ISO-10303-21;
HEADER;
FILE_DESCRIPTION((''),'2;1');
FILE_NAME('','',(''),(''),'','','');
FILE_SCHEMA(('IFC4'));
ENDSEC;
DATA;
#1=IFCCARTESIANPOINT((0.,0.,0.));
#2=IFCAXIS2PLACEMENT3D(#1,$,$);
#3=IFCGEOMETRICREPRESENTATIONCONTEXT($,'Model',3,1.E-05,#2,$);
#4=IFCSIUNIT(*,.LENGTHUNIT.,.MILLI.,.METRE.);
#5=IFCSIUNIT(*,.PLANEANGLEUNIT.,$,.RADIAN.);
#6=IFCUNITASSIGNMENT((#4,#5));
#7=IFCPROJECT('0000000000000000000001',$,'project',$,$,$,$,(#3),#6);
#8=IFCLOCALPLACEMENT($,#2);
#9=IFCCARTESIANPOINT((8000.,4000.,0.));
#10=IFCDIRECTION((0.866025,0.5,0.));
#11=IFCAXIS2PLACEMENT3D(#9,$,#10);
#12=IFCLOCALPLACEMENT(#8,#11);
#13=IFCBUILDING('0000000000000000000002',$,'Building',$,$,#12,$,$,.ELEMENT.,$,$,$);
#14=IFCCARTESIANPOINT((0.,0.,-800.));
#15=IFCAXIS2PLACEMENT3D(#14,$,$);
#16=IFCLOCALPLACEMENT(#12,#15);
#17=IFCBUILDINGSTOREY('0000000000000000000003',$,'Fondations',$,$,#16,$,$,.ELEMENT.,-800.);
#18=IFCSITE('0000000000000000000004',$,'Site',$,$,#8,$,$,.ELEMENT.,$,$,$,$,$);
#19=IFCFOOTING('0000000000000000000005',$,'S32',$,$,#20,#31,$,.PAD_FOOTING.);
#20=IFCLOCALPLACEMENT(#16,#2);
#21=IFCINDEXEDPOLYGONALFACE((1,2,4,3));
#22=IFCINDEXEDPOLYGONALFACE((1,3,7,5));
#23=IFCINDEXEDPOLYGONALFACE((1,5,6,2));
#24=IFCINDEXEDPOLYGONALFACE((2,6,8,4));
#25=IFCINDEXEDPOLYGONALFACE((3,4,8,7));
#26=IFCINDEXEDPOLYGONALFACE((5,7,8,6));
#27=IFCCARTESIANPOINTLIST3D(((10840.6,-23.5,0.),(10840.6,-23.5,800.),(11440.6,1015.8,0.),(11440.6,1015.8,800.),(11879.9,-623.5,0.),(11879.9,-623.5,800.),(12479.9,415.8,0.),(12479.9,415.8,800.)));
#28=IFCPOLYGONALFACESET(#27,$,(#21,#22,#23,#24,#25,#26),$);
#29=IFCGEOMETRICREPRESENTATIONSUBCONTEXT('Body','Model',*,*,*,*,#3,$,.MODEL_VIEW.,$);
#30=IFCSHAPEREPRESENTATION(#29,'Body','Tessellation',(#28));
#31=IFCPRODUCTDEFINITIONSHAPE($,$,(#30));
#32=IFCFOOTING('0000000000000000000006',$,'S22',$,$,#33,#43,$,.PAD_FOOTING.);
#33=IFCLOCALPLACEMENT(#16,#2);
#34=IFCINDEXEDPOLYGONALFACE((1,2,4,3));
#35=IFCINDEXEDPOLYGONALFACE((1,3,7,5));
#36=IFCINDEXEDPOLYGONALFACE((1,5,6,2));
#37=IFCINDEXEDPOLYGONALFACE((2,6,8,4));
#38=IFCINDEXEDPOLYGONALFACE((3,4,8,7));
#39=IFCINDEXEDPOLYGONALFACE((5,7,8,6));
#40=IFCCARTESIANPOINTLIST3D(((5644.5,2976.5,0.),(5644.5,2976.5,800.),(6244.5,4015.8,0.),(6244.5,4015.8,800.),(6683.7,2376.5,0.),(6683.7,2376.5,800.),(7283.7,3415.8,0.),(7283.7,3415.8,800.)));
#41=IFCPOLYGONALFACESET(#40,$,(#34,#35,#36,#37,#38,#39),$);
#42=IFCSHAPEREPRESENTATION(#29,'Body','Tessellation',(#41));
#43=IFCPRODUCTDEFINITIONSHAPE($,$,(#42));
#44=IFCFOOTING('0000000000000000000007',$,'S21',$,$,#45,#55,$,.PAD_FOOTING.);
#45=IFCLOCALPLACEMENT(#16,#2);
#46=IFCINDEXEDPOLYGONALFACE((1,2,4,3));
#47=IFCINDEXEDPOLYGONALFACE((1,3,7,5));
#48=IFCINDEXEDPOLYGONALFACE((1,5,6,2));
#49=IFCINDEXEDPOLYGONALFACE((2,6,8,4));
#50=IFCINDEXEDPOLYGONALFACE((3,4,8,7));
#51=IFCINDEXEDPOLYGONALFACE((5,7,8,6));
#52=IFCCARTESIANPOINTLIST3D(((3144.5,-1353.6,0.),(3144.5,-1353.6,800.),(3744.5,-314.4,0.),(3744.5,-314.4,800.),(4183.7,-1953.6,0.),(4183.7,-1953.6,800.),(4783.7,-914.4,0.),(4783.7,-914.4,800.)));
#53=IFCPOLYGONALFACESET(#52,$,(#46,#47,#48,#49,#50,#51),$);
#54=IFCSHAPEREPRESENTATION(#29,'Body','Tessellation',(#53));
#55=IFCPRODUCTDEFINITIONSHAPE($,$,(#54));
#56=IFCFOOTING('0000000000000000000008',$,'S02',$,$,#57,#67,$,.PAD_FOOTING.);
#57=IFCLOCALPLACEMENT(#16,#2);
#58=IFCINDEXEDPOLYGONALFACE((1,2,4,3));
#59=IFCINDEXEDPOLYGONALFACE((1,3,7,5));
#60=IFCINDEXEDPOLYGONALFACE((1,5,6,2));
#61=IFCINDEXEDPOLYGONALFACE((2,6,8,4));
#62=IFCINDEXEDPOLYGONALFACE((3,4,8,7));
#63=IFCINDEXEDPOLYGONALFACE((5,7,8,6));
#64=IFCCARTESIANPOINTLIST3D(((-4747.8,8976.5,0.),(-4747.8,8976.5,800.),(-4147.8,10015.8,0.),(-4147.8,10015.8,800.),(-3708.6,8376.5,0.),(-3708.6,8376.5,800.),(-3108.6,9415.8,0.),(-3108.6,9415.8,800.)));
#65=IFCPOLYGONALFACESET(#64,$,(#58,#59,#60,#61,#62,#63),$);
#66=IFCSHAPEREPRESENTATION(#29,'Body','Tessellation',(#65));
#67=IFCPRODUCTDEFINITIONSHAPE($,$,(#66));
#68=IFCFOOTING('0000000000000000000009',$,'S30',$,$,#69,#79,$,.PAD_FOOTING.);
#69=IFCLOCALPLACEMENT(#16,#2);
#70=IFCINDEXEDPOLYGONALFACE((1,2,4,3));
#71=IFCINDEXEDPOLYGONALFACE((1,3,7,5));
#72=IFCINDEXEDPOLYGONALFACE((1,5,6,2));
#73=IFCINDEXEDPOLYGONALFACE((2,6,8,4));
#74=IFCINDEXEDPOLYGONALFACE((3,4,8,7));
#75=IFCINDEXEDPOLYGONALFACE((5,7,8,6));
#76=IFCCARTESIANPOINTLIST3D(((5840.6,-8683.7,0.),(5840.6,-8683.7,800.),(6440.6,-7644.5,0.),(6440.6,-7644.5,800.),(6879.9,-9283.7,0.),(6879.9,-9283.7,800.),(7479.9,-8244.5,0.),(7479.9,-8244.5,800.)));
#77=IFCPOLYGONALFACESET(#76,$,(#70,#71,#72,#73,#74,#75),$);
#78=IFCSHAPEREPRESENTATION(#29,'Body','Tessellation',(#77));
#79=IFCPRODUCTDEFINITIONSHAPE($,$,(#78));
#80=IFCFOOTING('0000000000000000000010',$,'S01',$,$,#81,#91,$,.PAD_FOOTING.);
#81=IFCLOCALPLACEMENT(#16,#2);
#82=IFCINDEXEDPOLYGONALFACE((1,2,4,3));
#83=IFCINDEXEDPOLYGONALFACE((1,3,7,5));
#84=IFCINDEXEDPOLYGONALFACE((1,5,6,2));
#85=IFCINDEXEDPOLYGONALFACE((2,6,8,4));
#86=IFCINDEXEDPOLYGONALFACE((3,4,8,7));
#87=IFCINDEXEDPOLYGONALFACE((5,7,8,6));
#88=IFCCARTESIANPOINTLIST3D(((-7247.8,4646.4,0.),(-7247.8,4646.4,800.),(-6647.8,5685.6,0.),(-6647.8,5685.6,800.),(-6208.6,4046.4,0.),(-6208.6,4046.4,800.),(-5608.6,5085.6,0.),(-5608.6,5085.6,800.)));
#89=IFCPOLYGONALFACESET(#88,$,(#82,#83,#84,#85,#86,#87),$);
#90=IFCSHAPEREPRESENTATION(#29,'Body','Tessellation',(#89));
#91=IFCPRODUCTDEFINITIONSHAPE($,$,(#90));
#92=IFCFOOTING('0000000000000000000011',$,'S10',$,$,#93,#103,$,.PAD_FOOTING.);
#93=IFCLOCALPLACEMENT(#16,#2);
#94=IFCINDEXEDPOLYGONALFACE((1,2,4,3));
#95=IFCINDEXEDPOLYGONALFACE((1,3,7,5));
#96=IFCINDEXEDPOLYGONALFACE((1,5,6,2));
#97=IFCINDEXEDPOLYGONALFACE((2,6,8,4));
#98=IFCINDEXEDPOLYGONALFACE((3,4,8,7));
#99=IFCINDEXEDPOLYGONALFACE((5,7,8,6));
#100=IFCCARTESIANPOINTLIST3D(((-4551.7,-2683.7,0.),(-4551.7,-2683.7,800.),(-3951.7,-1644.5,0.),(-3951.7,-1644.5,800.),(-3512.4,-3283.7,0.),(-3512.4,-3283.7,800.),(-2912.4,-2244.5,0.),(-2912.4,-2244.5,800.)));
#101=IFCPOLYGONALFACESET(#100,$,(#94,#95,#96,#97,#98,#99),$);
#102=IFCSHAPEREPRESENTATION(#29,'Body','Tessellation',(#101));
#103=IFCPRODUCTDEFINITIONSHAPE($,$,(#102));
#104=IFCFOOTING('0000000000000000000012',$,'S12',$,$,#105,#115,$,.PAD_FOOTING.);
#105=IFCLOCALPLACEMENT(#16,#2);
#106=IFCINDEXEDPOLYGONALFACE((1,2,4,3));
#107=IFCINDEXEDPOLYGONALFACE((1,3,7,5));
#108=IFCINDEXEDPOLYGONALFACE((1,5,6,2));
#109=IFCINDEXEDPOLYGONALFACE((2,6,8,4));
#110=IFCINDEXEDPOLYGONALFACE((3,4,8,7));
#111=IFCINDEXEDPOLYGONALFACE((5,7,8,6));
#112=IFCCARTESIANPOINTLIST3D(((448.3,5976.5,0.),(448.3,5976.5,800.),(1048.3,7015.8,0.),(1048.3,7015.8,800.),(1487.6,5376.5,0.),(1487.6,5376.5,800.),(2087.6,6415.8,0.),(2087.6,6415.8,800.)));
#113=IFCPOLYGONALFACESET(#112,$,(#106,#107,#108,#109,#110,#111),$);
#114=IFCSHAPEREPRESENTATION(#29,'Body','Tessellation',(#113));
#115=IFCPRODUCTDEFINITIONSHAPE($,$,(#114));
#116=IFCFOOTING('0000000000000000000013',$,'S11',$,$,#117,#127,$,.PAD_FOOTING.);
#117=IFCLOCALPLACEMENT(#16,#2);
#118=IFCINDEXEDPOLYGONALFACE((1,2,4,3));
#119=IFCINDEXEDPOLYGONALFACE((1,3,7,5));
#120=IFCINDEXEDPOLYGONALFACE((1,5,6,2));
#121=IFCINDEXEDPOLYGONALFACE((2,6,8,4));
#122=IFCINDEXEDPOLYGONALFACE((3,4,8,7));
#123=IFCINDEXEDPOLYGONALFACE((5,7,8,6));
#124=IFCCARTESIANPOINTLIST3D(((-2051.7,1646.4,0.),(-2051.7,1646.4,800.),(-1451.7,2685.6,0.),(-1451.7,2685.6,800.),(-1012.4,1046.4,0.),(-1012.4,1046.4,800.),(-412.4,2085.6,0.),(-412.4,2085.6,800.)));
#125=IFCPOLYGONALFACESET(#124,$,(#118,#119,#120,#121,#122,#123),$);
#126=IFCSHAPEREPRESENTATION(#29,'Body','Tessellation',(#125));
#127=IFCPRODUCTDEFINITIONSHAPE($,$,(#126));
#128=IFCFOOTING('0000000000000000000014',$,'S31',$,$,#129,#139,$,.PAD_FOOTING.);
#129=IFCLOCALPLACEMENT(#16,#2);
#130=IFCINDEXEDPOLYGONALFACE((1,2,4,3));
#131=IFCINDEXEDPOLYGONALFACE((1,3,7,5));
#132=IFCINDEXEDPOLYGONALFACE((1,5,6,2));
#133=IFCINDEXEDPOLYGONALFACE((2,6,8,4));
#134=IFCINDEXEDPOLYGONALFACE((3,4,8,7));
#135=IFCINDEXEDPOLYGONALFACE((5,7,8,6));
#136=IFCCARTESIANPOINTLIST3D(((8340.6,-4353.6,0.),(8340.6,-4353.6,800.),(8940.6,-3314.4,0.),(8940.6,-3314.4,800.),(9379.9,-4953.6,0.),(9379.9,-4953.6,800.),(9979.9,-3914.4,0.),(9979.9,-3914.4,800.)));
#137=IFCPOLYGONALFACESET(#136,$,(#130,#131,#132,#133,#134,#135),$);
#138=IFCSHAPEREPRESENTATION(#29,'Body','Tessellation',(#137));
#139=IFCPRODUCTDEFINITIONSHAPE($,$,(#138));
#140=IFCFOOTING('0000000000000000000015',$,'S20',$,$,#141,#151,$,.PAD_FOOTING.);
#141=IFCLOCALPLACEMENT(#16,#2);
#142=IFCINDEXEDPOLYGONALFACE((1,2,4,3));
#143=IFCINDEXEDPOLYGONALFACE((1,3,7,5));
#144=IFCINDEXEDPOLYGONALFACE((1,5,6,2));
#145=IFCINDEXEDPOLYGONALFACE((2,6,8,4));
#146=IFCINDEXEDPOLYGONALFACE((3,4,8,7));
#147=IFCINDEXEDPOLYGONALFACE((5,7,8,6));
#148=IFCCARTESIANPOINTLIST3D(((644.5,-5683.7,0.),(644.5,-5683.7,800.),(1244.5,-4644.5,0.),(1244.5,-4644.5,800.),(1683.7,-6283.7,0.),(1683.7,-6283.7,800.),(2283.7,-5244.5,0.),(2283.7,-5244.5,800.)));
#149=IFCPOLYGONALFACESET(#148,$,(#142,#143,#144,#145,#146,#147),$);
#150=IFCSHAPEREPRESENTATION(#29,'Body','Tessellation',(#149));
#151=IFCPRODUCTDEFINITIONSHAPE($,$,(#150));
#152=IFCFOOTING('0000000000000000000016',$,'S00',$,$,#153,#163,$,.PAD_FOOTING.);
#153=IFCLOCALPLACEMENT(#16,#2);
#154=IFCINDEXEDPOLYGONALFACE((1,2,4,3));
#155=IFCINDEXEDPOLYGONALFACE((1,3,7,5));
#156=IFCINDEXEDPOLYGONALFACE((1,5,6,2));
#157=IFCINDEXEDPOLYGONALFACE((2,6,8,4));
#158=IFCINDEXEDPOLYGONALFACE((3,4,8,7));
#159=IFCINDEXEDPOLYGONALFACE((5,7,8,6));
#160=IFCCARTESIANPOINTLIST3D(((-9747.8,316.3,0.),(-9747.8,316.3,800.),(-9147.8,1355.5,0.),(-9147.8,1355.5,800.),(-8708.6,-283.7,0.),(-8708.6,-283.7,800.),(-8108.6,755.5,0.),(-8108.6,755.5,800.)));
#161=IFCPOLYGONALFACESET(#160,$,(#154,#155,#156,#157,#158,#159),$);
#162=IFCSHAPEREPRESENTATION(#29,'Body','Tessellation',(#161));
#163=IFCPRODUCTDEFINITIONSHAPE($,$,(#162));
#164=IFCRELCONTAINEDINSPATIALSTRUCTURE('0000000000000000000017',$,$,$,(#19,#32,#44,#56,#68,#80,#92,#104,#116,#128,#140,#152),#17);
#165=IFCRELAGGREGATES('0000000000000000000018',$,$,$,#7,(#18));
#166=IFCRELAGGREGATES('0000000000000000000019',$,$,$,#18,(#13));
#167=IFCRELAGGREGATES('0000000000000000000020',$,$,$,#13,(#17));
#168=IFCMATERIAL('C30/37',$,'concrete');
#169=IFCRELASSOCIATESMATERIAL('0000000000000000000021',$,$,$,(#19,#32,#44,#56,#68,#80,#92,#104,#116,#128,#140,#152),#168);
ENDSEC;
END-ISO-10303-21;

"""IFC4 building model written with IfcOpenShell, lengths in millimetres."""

from ifc_helpers import new_model, si_unit, frame, origin, place, context, subcontext, project, spatial, rectangle, extrude, material, element, save


model = new_model("IFC4")

# Units and contexts
model_context = context("Model", 3, precision=1e-05, world=origin())
body_context = subcontext(model_context, "Body", "Model", "MODEL_VIEW")
ifc_project = project(units=[si_unit("LENGTHUNIT", "METRE", prefix="MILLI"), si_unit("PLANEANGLEUNIT", "RADIAN")], contexts=[model_context])

# Site, building, storey
site_placement = place(None, origin())
site = spatial("IfcSite", under=ifc_project, at=site_placement, Name="Site", CompositionType="ELEMENT")
building_placement = place(site_placement, frame((8000.0, 4000.0, 0.0), x_axis=(0.866025, 0.5, 0.0)))
building = spatial("IfcBuilding", under=site, at=building_placement, Name="Building", CompositionType="ELEMENT")
storey_placement = place(building_placement, frame((0.0, 0.0, -800.0)))
storey = spatial("IfcBuildingStorey", under=building, at=storey_placement, Name="Fondations", CompositionType="ELEMENT", Elevation=-800.0)

# Footings
ifc_material = material(Name="C30/37", Category="concrete")
for number, where, z_axis, x_axis, name in (
    (1, (11660.3, 196.2, 0.0), (0.0, 0.0, 1.0), (0.866025, -0.5, 0.0), "S32"),
    (2, (6464.1, 3196.2, 0.0), (0.0, 0.0, 1.0), (0.866025, -0.5, 0.0), "S22"),
    (3, (3964.1, -1134.0, 0.0), (0.0, 0.0, 1.0), (0.866025, -0.5, 0.0), "S21"),
    (4, (-3928.2, 9196.2, 0.0), (0.0, 0.0, 1.0), (0.866025, -0.5, 0.0), "S02"),
    (5, (6660.3, -8464.1, 0.0), (0.0, 0.0, 1.0), (0.866025, -0.5, 0.0), "S30"),
    (6, (-6428.2, 4866.0, 0.0), (0.0, 0.0, 1.0), (0.866025, -0.5, 0.0), "S01"),
    (7, (-3732.1, -2464.1, 0.0), (0.0, 0.0, 1.0), (0.866025, -0.5, 0.0), "S10"),
    (8, (1267.9, 6196.2, 0.0), (0.0, 0.0, 1.0), (0.866025, -0.5, 0.0), "S12"),
    (9, (-1232.1, 1866.0, 0.0), (0.0, 0.0, 1.0), (0.866025, -0.5, 0.0), "S11"),
    (10, (9160.3, -4134.0, 0.0), (0.0, 0.0, 1.0), (0.866025, -0.5, 0.0), "S31"),
    (11, (1464.1, -5464.1, 0.0), (0.0, 0.0, 1.0), (0.866025, -0.5, 0.0), "S20"),
    (12, (-8928.2, 535.9, 0.0), (0.0, 0.0, 1.0), (0.866025, -0.5, 0.0), "S00"),
):
    element("IfcFooting", number, at=place(storey_placement, frame(where, z_axis=z_axis, x_axis=x_axis)), inside=storey, material=ifc_material, Name=name, PredefinedType="PAD_FOOTING", context=body_context, shape_type="SweptSolid", body=[
        extrude(rectangle(XDim=1200.0, YDim=1200.0), origin(), (0.0, 0.0, 1.0), 800.0),
    ])

save(model, "model.ifc")
